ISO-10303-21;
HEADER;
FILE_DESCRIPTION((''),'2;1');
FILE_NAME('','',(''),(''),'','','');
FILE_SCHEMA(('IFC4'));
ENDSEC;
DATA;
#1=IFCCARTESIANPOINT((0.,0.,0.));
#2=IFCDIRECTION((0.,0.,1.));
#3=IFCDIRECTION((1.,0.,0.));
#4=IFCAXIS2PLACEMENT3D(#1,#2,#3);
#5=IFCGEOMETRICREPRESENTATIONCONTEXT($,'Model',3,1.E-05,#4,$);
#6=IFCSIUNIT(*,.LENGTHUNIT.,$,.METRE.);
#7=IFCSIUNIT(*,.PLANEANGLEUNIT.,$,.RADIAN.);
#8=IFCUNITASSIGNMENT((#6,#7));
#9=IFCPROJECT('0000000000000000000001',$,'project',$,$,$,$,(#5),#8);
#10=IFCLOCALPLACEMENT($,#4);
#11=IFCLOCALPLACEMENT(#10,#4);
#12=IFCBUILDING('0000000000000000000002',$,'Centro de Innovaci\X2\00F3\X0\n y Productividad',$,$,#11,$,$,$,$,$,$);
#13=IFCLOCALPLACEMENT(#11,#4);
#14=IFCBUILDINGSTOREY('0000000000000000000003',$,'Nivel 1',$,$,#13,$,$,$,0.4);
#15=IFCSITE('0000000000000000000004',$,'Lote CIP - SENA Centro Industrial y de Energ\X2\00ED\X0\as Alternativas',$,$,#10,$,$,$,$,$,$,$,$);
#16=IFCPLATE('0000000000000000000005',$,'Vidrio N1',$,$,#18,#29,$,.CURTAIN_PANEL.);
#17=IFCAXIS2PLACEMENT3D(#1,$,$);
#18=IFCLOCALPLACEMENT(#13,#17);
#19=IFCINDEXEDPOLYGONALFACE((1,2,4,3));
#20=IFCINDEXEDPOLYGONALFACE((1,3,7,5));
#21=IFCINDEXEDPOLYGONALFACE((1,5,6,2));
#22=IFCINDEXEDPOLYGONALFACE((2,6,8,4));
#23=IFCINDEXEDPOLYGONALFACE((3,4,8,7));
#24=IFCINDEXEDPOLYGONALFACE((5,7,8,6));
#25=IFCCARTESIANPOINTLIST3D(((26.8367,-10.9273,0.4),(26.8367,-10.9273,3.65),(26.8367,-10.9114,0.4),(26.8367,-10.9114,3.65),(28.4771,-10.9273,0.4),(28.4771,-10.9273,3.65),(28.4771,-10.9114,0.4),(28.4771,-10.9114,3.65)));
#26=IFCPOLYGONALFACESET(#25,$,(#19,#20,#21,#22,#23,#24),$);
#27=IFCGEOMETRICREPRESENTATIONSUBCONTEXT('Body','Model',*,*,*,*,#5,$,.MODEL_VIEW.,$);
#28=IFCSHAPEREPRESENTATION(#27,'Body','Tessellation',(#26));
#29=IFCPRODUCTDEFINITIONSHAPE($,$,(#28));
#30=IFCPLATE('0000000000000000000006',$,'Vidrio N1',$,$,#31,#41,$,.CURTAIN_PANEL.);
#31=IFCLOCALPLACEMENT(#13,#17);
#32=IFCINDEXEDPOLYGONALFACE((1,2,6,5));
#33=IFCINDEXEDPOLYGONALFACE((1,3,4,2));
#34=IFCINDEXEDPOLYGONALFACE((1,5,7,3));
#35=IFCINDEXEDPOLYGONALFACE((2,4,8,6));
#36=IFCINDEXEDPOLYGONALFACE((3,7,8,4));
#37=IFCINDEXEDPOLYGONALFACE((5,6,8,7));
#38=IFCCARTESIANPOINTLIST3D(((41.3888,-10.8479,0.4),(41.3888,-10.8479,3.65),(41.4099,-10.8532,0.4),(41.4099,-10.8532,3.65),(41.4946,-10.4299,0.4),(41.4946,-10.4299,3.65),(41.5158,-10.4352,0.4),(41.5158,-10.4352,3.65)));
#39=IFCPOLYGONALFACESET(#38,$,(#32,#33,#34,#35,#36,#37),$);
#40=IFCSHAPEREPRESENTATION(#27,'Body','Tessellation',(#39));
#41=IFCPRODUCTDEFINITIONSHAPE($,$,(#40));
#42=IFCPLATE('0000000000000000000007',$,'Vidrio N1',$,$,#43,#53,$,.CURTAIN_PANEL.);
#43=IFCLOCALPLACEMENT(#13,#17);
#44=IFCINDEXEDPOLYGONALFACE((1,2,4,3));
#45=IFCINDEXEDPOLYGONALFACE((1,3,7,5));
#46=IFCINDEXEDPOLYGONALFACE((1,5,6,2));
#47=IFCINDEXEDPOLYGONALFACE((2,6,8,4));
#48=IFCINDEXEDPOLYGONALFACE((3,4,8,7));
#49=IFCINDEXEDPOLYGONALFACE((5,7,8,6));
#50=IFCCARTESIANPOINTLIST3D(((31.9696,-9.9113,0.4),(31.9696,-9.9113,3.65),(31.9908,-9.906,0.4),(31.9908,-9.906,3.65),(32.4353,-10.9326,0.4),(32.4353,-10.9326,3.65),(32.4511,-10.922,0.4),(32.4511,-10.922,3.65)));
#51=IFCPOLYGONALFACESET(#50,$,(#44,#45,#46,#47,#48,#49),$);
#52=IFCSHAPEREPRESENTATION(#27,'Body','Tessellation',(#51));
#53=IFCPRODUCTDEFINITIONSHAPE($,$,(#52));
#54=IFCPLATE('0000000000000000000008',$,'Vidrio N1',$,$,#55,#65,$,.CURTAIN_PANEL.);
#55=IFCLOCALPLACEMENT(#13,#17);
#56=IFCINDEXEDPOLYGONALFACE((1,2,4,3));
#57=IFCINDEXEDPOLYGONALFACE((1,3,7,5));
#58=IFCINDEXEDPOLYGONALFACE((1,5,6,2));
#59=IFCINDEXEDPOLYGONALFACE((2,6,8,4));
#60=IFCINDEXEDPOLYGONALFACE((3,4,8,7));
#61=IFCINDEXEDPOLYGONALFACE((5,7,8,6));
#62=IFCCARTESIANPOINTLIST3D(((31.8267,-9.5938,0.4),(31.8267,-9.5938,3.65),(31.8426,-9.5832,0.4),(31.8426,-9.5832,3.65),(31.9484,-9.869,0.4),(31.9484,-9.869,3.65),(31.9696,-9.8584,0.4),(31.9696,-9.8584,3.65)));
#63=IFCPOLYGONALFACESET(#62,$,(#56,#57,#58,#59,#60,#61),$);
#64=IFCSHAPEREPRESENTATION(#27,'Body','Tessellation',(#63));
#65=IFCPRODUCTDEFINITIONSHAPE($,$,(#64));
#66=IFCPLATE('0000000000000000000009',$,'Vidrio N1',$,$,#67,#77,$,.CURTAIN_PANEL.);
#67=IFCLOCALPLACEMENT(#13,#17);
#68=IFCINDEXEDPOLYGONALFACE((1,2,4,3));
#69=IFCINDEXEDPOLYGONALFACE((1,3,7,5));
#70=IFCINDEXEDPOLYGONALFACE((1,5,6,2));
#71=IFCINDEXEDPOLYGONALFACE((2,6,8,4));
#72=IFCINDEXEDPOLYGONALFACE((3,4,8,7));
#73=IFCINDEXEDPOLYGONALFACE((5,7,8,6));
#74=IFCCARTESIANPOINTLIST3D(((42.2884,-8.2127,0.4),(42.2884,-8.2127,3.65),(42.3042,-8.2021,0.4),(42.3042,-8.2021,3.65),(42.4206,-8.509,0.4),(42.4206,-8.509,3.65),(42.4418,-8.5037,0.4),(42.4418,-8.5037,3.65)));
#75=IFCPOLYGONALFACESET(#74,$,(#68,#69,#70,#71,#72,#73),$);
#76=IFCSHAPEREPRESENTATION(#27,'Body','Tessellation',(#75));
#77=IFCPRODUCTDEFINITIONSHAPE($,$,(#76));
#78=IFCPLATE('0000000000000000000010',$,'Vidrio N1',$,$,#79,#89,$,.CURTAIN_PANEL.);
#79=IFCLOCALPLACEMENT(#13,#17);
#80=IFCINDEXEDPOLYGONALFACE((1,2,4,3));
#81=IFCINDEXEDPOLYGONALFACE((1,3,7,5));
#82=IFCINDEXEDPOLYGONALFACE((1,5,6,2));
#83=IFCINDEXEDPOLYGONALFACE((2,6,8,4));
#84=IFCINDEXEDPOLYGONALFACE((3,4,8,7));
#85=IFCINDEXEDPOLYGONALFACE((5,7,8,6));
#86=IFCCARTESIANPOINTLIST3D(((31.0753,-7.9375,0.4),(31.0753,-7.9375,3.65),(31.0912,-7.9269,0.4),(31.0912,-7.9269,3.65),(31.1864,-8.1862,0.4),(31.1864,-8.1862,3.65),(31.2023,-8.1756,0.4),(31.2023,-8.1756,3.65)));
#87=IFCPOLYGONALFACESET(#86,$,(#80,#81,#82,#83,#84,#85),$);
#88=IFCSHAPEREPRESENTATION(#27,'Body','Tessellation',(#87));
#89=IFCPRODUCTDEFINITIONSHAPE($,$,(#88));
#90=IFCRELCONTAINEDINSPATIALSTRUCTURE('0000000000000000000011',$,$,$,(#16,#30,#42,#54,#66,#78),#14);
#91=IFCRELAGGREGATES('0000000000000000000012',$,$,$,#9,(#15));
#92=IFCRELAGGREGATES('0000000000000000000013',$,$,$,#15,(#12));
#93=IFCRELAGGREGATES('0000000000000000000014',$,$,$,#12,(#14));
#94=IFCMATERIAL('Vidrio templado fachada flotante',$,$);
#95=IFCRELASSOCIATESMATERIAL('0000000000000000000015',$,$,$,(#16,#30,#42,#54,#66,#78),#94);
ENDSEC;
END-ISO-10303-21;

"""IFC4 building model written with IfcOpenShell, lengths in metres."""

from ifc_helpers import new_model, si_unit, frame, origin_with_axes, place, context, subcontext, project, spatial, polyline, outline, extrude, material, element, save


model = new_model("IFC4")

# Units and contexts
model_context = context("Model", 3, precision=1e-05, world=origin_with_axes())
body_context = subcontext(model_context, "Body", "Model", "MODEL_VIEW")
ifc_project = project(units=[si_unit("LENGTHUNIT", "METRE"), si_unit("PLANEANGLEUNIT", "RADIAN")], contexts=[model_context])

# Site, building, storey
site_placement = place(None, origin_with_axes())
site = spatial("IfcSite", under=ifc_project, at=site_placement, Name="Lote CIP - SENA Centro Industrial y de Energías Alternativas")
building_placement = place(site_placement, origin_with_axes())
building = spatial("IfcBuilding", under=site, at=building_placement, Name="Centro de Innovación y Productividad")
storey_placement = place(building_placement, origin_with_axes())
storey = spatial("IfcBuildingStorey", under=building, at=storey_placement, Name="Nivel 1", Elevation=0.4)

# Plates
ifc_material = material(Name="Vidrio templado fachada flotante")
plate_1_placement = place(storey_placement, origin_with_axes())
element("IfcPlate", 1, at=plate_1_placement, inside=storey, material=ifc_material, Name="Vidrio N1", PredefinedType="CURTAIN_PANEL", context=body_context, shape_type="SweptSolid", body=[
    extrude(outline(polyline([(28.4771, -10.9114), (28.4771, -10.9273), (26.8367, -10.9273), (26.8367, -10.9114), (28.4771, -10.9114)])), frame((0.0, 0.0, 0.4)), (0.0, 0.0, 1.0), 3.25),
])
plate_2_placement = place(storey_placement, origin_with_axes())
element("IfcPlate", 2, at=plate_2_placement, inside=storey, material=ifc_material, Name="Vidrio N1", PredefinedType="CURTAIN_PANEL", context=body_context, shape_type="SweptSolid", body=[
    extrude(outline(polyline([(41.4099, -10.8532), (41.3888, -10.8479), (41.4946, -10.4299), (41.5158, -10.4352), (41.4099, -10.8532)])), frame((0.0, 0.0, 0.4)), (0.0, 0.0, 1.0), 3.25),
])
plate_3_placement = place(storey_placement, origin_with_axes())
element("IfcPlate", 3, at=plate_3_placement, inside=storey, material=ifc_material, Name="Vidrio N1", PredefinedType="CURTAIN_PANEL", context=body_context, shape_type="SweptSolid", body=[
    extrude(outline(polyline([(32.4511, -10.922), (32.4353, -10.9326), (31.9696, -9.9113), (31.9908, -9.906), (32.4511, -10.922)])), frame((0.0, 0.0, 0.4)), (0.0, 0.0, 1.0), 3.25),
])
plate_4_placement = place(storey_placement, origin_with_axes())
element("IfcPlate", 4, at=plate_4_placement, inside=storey, material=ifc_material, Name="Vidrio N1", PredefinedType="CURTAIN_PANEL", context=body_context, shape_type="SweptSolid", body=[
    extrude(outline(polyline([(31.8267, -9.5938), (31.8426, -9.5832), (31.9696, -9.8584), (31.9484, -9.869), (31.8267, -9.5938)])), frame((0.0, 0.0, 0.4)), (0.0, 0.0, 1.0), 3.25),
])
plate_5_placement = place(storey_placement, origin_with_axes())
element("IfcPlate", 5, at=plate_5_placement, inside=storey, material=ifc_material, Name="Vidrio N1", PredefinedType="CURTAIN_PANEL", context=body_context, shape_type="SweptSolid", body=[
    extrude(outline(polyline([(42.4206, -8.509), (42.2884, -8.2127), (42.3042, -8.2021), (42.4418, -8.5037), (42.4206, -8.509)])), frame((0.0, 0.0, 0.4)), (0.0, 0.0, 1.0), 3.25),
])
plate_6_placement = place(storey_placement, origin_with_axes())
element("IfcPlate", 6, at=plate_6_placement, inside=storey, material=ifc_material, Name="Vidrio N1", PredefinedType="CURTAIN_PANEL", context=body_context, shape_type="SweptSolid", body=[
    extrude(outline(polyline([(31.1864, -8.1862), (31.0753, -7.9375), (31.0912, -7.9269), (31.2023, -8.1756), (31.1864, -8.1862)])), frame((0.0, 0.0, 0.4)), (0.0, 0.0, 1.0), 3.25),
])

save(model, "model.ifc")
